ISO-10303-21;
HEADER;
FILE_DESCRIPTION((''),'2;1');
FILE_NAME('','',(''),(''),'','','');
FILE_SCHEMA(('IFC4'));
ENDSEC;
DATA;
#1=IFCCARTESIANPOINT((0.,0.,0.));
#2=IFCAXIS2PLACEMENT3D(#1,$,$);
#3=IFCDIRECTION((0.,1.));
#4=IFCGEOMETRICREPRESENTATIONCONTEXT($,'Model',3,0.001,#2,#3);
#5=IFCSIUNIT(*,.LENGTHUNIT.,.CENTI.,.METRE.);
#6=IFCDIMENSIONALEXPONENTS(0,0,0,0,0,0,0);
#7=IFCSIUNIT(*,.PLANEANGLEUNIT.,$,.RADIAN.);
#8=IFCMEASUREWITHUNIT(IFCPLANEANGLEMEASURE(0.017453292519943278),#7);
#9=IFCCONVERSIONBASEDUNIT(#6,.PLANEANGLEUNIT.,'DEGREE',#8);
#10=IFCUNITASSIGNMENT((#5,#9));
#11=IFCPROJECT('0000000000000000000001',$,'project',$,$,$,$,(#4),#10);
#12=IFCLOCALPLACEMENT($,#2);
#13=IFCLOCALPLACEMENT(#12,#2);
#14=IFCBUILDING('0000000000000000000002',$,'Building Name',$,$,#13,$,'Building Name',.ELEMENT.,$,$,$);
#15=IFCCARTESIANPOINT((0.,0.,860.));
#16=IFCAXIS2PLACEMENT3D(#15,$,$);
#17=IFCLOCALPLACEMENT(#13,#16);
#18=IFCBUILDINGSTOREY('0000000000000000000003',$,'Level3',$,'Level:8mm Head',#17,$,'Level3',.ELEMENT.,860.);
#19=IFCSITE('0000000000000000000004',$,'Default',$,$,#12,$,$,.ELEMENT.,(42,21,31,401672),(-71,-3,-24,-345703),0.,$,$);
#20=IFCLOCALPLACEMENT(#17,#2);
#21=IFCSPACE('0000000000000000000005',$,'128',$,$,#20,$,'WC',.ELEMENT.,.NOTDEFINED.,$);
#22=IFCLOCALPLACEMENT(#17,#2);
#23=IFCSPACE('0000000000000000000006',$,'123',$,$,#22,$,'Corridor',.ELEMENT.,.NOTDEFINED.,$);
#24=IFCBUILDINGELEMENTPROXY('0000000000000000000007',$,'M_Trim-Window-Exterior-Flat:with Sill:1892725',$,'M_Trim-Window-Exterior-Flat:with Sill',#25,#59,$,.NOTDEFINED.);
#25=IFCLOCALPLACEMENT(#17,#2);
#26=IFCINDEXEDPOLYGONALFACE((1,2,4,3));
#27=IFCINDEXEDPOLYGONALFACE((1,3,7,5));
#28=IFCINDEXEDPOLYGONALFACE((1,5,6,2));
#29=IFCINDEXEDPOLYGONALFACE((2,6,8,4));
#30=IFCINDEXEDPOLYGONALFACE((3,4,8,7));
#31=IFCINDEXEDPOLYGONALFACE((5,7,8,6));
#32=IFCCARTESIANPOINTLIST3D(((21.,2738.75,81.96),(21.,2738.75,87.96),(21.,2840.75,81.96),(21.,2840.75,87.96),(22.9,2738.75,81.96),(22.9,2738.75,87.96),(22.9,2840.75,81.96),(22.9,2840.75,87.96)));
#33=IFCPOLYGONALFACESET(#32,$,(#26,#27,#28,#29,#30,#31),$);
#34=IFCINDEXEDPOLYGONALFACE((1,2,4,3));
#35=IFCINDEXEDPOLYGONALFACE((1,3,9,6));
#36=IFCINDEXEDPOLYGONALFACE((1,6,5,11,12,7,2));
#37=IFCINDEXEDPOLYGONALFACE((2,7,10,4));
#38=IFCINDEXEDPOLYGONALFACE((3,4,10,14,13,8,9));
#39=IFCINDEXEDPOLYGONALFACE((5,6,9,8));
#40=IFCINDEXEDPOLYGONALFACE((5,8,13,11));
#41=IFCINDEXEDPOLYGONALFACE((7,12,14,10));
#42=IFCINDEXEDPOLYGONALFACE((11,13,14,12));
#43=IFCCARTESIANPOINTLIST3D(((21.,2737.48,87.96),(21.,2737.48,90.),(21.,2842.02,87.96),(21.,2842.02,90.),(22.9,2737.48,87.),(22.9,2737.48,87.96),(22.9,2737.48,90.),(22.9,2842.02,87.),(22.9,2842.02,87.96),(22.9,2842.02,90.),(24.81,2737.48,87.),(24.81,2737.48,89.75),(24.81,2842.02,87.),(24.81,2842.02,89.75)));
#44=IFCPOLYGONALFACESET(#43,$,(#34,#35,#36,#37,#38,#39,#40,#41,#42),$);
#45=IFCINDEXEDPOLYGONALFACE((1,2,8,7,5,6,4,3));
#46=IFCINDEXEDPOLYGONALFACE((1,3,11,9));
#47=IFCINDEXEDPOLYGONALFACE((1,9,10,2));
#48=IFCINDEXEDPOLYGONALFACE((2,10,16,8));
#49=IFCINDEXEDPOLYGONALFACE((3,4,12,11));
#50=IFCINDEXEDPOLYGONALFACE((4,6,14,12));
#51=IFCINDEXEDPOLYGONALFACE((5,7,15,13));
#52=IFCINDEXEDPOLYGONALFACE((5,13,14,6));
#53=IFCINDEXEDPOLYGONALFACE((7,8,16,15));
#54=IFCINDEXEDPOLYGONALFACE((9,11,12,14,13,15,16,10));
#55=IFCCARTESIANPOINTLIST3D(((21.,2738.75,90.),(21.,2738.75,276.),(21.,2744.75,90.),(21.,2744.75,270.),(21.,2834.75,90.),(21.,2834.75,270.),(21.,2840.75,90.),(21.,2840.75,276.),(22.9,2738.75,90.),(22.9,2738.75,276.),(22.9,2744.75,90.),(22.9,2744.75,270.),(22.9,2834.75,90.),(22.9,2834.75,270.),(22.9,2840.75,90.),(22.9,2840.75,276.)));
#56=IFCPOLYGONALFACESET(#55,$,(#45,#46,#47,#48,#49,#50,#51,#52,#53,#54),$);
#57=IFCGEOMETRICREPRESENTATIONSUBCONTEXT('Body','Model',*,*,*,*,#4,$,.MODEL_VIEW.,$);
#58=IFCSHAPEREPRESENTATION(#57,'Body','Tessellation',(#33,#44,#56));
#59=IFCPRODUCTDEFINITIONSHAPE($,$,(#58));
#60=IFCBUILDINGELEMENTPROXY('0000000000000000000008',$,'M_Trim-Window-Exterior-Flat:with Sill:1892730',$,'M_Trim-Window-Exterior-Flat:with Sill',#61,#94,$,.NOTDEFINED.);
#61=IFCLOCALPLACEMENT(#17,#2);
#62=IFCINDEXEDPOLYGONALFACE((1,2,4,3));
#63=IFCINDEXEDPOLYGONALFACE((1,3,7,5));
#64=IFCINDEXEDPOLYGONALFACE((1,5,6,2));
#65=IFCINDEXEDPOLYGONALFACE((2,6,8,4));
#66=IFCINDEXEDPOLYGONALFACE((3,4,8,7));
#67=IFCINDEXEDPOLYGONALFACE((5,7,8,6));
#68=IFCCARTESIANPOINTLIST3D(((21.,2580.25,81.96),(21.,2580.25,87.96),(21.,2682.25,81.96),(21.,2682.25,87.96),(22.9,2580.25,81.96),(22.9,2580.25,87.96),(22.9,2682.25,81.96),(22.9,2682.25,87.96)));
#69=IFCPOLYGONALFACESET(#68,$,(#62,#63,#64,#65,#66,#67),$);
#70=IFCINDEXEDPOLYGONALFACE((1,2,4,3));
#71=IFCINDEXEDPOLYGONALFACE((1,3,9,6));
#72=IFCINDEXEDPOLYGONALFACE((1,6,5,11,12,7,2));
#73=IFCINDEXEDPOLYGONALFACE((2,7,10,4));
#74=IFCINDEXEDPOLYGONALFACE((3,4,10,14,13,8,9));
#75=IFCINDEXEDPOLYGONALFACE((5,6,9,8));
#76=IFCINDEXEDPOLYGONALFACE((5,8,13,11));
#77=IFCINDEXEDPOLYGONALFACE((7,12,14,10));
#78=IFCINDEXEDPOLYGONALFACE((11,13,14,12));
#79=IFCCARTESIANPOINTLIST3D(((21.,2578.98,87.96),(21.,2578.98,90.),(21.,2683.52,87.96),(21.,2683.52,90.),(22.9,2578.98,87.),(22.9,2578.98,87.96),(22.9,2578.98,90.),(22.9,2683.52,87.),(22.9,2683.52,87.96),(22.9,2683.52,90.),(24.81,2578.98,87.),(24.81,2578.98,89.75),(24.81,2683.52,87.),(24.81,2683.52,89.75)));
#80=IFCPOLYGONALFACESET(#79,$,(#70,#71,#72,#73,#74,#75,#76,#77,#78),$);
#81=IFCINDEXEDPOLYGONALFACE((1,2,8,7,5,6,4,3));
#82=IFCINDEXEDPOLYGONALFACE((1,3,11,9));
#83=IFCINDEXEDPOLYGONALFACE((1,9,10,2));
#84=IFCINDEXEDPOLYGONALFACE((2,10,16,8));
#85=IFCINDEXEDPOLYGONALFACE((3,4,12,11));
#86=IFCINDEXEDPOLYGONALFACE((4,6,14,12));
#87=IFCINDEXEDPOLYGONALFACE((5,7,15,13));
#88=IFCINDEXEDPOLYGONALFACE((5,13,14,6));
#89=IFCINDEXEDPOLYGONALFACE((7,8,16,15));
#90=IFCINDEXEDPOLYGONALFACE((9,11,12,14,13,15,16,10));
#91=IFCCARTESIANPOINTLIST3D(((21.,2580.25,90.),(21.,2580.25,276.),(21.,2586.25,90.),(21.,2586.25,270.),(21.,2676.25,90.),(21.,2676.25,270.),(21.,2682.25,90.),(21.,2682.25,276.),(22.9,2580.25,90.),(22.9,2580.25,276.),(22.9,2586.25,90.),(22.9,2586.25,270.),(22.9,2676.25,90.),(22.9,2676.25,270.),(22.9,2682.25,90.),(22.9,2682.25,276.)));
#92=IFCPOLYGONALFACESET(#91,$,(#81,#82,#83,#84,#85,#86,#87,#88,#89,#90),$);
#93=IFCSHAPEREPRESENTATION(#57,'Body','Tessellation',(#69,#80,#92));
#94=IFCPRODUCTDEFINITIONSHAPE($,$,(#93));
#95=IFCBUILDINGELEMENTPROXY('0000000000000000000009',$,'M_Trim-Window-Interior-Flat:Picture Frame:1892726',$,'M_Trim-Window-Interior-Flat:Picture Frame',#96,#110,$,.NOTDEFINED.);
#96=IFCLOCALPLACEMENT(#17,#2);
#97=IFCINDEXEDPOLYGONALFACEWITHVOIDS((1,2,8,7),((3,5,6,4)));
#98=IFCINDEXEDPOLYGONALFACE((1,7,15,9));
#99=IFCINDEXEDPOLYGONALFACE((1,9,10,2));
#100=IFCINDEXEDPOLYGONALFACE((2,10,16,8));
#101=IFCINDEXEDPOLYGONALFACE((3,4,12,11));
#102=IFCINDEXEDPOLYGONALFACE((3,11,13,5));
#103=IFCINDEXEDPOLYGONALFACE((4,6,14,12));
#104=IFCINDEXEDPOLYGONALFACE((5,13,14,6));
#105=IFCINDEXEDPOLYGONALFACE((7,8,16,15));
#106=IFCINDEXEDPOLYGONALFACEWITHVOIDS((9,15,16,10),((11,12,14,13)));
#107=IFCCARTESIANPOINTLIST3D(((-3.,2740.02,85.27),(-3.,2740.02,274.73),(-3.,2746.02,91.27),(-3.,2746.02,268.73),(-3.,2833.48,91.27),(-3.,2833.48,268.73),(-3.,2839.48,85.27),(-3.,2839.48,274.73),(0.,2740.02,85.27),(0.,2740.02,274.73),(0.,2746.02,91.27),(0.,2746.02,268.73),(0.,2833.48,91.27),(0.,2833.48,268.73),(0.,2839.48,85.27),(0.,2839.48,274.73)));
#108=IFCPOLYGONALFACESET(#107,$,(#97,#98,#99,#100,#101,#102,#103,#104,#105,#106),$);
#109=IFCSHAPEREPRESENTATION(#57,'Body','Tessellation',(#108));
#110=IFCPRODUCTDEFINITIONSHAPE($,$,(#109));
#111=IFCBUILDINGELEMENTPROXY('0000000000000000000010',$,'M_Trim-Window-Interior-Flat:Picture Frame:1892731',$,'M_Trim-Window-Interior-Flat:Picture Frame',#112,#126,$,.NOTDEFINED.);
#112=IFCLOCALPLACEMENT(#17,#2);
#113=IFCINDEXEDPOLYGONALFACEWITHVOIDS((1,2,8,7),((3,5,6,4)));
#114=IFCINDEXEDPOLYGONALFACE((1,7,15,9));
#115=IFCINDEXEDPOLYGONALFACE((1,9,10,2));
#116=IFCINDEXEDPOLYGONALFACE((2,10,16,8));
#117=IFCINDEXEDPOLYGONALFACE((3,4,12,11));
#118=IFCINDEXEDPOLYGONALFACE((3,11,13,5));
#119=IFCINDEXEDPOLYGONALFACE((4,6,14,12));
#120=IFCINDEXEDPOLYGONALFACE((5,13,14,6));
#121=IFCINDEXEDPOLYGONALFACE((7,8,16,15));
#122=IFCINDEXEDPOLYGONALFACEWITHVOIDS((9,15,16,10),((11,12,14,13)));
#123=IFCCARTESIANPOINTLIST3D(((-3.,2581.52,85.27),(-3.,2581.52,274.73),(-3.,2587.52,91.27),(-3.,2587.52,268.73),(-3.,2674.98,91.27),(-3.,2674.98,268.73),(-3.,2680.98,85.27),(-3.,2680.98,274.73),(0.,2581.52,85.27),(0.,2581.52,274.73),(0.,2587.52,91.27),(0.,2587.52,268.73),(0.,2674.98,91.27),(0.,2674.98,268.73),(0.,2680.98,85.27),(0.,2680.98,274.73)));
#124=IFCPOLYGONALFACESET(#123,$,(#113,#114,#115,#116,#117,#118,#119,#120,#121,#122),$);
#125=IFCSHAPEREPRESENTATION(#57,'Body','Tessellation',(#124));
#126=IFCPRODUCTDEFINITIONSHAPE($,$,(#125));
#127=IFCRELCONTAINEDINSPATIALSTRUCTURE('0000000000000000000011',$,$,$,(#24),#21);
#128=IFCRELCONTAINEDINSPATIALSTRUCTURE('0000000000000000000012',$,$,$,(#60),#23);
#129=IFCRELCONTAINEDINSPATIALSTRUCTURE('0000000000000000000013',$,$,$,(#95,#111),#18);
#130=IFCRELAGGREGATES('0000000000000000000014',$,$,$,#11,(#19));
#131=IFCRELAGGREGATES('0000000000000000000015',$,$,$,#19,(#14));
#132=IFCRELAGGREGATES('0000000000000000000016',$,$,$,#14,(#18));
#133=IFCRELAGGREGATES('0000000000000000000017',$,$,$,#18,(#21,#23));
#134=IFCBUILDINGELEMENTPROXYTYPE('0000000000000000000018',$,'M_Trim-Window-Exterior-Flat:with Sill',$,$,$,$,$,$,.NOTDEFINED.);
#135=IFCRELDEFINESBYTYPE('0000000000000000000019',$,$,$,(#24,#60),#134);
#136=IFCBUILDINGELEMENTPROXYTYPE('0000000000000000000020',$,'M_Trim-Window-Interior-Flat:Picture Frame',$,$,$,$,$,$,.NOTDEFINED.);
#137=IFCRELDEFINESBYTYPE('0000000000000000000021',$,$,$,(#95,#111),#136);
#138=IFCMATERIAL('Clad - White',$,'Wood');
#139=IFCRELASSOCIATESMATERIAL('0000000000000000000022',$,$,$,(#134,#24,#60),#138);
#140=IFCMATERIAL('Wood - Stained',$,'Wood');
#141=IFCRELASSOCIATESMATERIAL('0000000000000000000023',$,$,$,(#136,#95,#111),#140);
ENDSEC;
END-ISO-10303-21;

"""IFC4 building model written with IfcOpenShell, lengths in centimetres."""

from ifc_helpers import new_model, entity, si_unit, converted_unit, direction, frame, origin, place, context, subcontext, project, spatial, indexed_curve, outline, extrude, source, transform, mapped, material, type_object, type_shapes, element, save


model = new_model("IFC4")

# Units and contexts
model_context = context("Model", 3, precision=0.001, world=origin(), true_north=direction((0.0, 1.0)))
body_context = subcontext(model_context, "Body", "Model", "MODEL_VIEW")
ifc_project = project(units=[si_unit("LENGTHUNIT", "METRE", prefix="CENTI"), converted_unit("PLANEANGLEUNIT", "DEGREE", entity("IfcPlaneAngleMeasure", 0.017453292519943278), si_unit("PLANEANGLEUNIT", "RADIAN"), dimensions=[0, 0, 0, 0, 0, 0, 0])], contexts=[model_context])

# Site, building, storey
site_placement = place(None, origin())
site = spatial("IfcSite", under=ifc_project, at=site_placement, Name="Default", CompositionType="ELEMENT", RefLatitude=(42, 21, 31, 401672), RefLongitude=(-71, -3, -24, -345703), RefElevation=0.0)
building_placement = place(site_placement, origin())
building = spatial("IfcBuilding", under=site, at=building_placement, Name="Building Name", LongName="Building Name", CompositionType="ELEMENT")
storey_placement = place(building_placement, frame((0.0, 0.0, 860.0)))
storey = spatial("IfcBuildingStorey", under=building, at=storey_placement, Name="Level3", ObjectType="Level:8mm Head", LongName="Level3", CompositionType="ELEMENT", Elevation=860.0)

# Shared definitions
ifc_material_1 = material(Name="Wood - Stained", Category="Wood")

# Shared definitions
ifc_material_2 = material(Name="Clad - White", Category="Wood")

# Shared definitions
space_1_placement = place(storey_placement, origin())
space_1 = spatial("IfcSpace", under=storey, at=space_1_placement, Name="128", LongName="WC", CompositionType="ELEMENT", PredefinedType="NOTDEFINED")

# Building element proxy
building_element_proxy_type_1 = type_object("IfcBuildingElementProxyType", Name="M_Trim-Window-Exterior-Flat:with Sill", PredefinedType="NOTDEFINED", material=ifc_material_2)
shared_shape_1 = source(origin(), body_context, "Body", "SweptSolid", [
    extrude(outline(indexed_curve([(-51.0, -3.0), (51.0, -3.0), (51.0, 3.0), (-51.0, 3.0), (-51.0, -3.0)], self_intersect=False)), frame((0.0, -185.04, 0.0), z_axis=(0.0, 0.0, 1.0), x_axis=(-1.0, 0.0, 0.0)), (0.0, 0.0, 1.0), 1.9),
    extrude(outline(indexed_curve([(-1.9, -1.52), (0.0, -1.52), (0.0, -0.57), (1.9, -0.57), (1.9, 1.48), (0.0, 1.48), (-1.9, 1.23), (-1.9, -1.52)], self_intersect=False)), frame((-52.27, -181.48, 1.9), z_axis=(1.0, 0.0, 0.0), x_axis=(0.0, 0.0, -1.0)), (0.0, 0.0, 1.0), 104.54),
    extrude(outline(indexed_curve([(-94.5, -51.0), (91.5, -51.0), (91.5, -45.0), (-88.5, -45.0), (-88.5, 45.0), (91.5, 45.0), (91.5, 51.0), (-94.5, 51.0), (-94.5, -51.0)], self_intersect=False)), frame((0.0, -88.5, 0.0), z_axis=(0.0, 0.0, 1.0), x_axis=(0.0, -1.0, 0.0)), (0.0, 0.0, 1.0), 1.9),
])
type_shapes(building_element_proxy_type_1, [shared_shape_1])
proxy_1_placement = place(space_1_placement, frame((21.0, 2789.75, 270.0), z_axis=(1.0, 0.0, 0.0), x_axis=(0.0, 1.0, 0.0)))
element("IfcBuildingElementProxy", 1, at=proxy_1_placement, inside=space_1, type_object=building_element_proxy_type_1, material=ifc_material_2, Name="M_Trim-Window-Exterior-Flat:with Sill:1892725", ObjectType="M_Trim-Window-Exterior-Flat:with Sill", PredefinedType="NOTDEFINED", context=body_context, shape_type="MappedRepresentation", body=[
    mapped(shared_shape_1, transform((0.0, 0.0, 0.0), scale=1.0)),
])

# Shared definitions
space_2_placement = place(storey_placement, origin())
space_2 = spatial("IfcSpace", under=storey, at=space_2_placement, Name="123", LongName="Corridor", CompositionType="ELEMENT", PredefinedType="NOTDEFINED")

# Building element proxies
proxy_2_placement = place(space_2_placement, frame((21.0, 2631.25, 270.0), z_axis=(1.0, 0.0, 0.0), x_axis=(0.0, 1.0, 0.0)))
element("IfcBuildingElementProxy", 2, at=proxy_2_placement, inside=space_2, type_object=building_element_proxy_type_1, material=ifc_material_2, Name="M_Trim-Window-Exterior-Flat:with Sill:1892730", ObjectType="M_Trim-Window-Exterior-Flat:with Sill", PredefinedType="NOTDEFINED", context=body_context, shape_type="MappedRepresentation", body=[
    mapped(shared_shape_1, transform((0.0, 0.0, 0.0), scale=1.0)),
])
building_element_proxy_type_2 = type_object("IfcBuildingElementProxyType", Name="M_Trim-Window-Interior-Flat:Picture Frame", PredefinedType="NOTDEFINED", material=ifc_material_1)
shared_shape_2 = source(origin(), body_context, "Body", "SweptSolid", [
    extrude(outline(indexed_curve([(-49.73, -94.73), (49.73, -94.73), (49.73, 94.73), (-49.73, 94.73), (-49.73, -94.73)], self_intersect=False), holes=[indexed_curve([(-43.73, -88.73), (-43.73, 88.73), (43.73, 88.73), (43.73, -88.73), (-43.73, -88.73)], self_intersect=False)]), frame((0.0, -90.0, 0.0), z_axis=(0.0, 0.0, 1.0), x_axis=(-1.0, 0.0, 0.0)), (0.0, 0.0, 1.0), 3.0),
])
type_shapes(building_element_proxy_type_2, [shared_shape_2])
for number, where, z_axis, x_axis, name in (
    (3, (0.0, 2789.75, 270.0), (-1.0, 0.0, 0.0), (0.0, -1.0, 0.0), "M_Trim-Window-Interior-Flat:Picture Frame:1892726"),
    (4, (0.0, 2631.25, 270.0), (-1.0, 0.0, 0.0), (0.0, -1.0, 0.0), "M_Trim-Window-Interior-Flat:Picture Frame:1892731"),
):
    element("IfcBuildingElementProxy", number, at=place(storey_placement, frame(where, z_axis=z_axis, x_axis=x_axis)), inside=storey, type_object=building_element_proxy_type_2, material=ifc_material_1, Name=name, ObjectType="M_Trim-Window-Interior-Flat:Picture Frame", PredefinedType="NOTDEFINED", context=body_context, shape_type="MappedRepresentation", body=[
        mapped(shared_shape_2, transform((0.0, 0.0, 0.0), scale=1.0)),
    ])

save(model, "model.ifc")
